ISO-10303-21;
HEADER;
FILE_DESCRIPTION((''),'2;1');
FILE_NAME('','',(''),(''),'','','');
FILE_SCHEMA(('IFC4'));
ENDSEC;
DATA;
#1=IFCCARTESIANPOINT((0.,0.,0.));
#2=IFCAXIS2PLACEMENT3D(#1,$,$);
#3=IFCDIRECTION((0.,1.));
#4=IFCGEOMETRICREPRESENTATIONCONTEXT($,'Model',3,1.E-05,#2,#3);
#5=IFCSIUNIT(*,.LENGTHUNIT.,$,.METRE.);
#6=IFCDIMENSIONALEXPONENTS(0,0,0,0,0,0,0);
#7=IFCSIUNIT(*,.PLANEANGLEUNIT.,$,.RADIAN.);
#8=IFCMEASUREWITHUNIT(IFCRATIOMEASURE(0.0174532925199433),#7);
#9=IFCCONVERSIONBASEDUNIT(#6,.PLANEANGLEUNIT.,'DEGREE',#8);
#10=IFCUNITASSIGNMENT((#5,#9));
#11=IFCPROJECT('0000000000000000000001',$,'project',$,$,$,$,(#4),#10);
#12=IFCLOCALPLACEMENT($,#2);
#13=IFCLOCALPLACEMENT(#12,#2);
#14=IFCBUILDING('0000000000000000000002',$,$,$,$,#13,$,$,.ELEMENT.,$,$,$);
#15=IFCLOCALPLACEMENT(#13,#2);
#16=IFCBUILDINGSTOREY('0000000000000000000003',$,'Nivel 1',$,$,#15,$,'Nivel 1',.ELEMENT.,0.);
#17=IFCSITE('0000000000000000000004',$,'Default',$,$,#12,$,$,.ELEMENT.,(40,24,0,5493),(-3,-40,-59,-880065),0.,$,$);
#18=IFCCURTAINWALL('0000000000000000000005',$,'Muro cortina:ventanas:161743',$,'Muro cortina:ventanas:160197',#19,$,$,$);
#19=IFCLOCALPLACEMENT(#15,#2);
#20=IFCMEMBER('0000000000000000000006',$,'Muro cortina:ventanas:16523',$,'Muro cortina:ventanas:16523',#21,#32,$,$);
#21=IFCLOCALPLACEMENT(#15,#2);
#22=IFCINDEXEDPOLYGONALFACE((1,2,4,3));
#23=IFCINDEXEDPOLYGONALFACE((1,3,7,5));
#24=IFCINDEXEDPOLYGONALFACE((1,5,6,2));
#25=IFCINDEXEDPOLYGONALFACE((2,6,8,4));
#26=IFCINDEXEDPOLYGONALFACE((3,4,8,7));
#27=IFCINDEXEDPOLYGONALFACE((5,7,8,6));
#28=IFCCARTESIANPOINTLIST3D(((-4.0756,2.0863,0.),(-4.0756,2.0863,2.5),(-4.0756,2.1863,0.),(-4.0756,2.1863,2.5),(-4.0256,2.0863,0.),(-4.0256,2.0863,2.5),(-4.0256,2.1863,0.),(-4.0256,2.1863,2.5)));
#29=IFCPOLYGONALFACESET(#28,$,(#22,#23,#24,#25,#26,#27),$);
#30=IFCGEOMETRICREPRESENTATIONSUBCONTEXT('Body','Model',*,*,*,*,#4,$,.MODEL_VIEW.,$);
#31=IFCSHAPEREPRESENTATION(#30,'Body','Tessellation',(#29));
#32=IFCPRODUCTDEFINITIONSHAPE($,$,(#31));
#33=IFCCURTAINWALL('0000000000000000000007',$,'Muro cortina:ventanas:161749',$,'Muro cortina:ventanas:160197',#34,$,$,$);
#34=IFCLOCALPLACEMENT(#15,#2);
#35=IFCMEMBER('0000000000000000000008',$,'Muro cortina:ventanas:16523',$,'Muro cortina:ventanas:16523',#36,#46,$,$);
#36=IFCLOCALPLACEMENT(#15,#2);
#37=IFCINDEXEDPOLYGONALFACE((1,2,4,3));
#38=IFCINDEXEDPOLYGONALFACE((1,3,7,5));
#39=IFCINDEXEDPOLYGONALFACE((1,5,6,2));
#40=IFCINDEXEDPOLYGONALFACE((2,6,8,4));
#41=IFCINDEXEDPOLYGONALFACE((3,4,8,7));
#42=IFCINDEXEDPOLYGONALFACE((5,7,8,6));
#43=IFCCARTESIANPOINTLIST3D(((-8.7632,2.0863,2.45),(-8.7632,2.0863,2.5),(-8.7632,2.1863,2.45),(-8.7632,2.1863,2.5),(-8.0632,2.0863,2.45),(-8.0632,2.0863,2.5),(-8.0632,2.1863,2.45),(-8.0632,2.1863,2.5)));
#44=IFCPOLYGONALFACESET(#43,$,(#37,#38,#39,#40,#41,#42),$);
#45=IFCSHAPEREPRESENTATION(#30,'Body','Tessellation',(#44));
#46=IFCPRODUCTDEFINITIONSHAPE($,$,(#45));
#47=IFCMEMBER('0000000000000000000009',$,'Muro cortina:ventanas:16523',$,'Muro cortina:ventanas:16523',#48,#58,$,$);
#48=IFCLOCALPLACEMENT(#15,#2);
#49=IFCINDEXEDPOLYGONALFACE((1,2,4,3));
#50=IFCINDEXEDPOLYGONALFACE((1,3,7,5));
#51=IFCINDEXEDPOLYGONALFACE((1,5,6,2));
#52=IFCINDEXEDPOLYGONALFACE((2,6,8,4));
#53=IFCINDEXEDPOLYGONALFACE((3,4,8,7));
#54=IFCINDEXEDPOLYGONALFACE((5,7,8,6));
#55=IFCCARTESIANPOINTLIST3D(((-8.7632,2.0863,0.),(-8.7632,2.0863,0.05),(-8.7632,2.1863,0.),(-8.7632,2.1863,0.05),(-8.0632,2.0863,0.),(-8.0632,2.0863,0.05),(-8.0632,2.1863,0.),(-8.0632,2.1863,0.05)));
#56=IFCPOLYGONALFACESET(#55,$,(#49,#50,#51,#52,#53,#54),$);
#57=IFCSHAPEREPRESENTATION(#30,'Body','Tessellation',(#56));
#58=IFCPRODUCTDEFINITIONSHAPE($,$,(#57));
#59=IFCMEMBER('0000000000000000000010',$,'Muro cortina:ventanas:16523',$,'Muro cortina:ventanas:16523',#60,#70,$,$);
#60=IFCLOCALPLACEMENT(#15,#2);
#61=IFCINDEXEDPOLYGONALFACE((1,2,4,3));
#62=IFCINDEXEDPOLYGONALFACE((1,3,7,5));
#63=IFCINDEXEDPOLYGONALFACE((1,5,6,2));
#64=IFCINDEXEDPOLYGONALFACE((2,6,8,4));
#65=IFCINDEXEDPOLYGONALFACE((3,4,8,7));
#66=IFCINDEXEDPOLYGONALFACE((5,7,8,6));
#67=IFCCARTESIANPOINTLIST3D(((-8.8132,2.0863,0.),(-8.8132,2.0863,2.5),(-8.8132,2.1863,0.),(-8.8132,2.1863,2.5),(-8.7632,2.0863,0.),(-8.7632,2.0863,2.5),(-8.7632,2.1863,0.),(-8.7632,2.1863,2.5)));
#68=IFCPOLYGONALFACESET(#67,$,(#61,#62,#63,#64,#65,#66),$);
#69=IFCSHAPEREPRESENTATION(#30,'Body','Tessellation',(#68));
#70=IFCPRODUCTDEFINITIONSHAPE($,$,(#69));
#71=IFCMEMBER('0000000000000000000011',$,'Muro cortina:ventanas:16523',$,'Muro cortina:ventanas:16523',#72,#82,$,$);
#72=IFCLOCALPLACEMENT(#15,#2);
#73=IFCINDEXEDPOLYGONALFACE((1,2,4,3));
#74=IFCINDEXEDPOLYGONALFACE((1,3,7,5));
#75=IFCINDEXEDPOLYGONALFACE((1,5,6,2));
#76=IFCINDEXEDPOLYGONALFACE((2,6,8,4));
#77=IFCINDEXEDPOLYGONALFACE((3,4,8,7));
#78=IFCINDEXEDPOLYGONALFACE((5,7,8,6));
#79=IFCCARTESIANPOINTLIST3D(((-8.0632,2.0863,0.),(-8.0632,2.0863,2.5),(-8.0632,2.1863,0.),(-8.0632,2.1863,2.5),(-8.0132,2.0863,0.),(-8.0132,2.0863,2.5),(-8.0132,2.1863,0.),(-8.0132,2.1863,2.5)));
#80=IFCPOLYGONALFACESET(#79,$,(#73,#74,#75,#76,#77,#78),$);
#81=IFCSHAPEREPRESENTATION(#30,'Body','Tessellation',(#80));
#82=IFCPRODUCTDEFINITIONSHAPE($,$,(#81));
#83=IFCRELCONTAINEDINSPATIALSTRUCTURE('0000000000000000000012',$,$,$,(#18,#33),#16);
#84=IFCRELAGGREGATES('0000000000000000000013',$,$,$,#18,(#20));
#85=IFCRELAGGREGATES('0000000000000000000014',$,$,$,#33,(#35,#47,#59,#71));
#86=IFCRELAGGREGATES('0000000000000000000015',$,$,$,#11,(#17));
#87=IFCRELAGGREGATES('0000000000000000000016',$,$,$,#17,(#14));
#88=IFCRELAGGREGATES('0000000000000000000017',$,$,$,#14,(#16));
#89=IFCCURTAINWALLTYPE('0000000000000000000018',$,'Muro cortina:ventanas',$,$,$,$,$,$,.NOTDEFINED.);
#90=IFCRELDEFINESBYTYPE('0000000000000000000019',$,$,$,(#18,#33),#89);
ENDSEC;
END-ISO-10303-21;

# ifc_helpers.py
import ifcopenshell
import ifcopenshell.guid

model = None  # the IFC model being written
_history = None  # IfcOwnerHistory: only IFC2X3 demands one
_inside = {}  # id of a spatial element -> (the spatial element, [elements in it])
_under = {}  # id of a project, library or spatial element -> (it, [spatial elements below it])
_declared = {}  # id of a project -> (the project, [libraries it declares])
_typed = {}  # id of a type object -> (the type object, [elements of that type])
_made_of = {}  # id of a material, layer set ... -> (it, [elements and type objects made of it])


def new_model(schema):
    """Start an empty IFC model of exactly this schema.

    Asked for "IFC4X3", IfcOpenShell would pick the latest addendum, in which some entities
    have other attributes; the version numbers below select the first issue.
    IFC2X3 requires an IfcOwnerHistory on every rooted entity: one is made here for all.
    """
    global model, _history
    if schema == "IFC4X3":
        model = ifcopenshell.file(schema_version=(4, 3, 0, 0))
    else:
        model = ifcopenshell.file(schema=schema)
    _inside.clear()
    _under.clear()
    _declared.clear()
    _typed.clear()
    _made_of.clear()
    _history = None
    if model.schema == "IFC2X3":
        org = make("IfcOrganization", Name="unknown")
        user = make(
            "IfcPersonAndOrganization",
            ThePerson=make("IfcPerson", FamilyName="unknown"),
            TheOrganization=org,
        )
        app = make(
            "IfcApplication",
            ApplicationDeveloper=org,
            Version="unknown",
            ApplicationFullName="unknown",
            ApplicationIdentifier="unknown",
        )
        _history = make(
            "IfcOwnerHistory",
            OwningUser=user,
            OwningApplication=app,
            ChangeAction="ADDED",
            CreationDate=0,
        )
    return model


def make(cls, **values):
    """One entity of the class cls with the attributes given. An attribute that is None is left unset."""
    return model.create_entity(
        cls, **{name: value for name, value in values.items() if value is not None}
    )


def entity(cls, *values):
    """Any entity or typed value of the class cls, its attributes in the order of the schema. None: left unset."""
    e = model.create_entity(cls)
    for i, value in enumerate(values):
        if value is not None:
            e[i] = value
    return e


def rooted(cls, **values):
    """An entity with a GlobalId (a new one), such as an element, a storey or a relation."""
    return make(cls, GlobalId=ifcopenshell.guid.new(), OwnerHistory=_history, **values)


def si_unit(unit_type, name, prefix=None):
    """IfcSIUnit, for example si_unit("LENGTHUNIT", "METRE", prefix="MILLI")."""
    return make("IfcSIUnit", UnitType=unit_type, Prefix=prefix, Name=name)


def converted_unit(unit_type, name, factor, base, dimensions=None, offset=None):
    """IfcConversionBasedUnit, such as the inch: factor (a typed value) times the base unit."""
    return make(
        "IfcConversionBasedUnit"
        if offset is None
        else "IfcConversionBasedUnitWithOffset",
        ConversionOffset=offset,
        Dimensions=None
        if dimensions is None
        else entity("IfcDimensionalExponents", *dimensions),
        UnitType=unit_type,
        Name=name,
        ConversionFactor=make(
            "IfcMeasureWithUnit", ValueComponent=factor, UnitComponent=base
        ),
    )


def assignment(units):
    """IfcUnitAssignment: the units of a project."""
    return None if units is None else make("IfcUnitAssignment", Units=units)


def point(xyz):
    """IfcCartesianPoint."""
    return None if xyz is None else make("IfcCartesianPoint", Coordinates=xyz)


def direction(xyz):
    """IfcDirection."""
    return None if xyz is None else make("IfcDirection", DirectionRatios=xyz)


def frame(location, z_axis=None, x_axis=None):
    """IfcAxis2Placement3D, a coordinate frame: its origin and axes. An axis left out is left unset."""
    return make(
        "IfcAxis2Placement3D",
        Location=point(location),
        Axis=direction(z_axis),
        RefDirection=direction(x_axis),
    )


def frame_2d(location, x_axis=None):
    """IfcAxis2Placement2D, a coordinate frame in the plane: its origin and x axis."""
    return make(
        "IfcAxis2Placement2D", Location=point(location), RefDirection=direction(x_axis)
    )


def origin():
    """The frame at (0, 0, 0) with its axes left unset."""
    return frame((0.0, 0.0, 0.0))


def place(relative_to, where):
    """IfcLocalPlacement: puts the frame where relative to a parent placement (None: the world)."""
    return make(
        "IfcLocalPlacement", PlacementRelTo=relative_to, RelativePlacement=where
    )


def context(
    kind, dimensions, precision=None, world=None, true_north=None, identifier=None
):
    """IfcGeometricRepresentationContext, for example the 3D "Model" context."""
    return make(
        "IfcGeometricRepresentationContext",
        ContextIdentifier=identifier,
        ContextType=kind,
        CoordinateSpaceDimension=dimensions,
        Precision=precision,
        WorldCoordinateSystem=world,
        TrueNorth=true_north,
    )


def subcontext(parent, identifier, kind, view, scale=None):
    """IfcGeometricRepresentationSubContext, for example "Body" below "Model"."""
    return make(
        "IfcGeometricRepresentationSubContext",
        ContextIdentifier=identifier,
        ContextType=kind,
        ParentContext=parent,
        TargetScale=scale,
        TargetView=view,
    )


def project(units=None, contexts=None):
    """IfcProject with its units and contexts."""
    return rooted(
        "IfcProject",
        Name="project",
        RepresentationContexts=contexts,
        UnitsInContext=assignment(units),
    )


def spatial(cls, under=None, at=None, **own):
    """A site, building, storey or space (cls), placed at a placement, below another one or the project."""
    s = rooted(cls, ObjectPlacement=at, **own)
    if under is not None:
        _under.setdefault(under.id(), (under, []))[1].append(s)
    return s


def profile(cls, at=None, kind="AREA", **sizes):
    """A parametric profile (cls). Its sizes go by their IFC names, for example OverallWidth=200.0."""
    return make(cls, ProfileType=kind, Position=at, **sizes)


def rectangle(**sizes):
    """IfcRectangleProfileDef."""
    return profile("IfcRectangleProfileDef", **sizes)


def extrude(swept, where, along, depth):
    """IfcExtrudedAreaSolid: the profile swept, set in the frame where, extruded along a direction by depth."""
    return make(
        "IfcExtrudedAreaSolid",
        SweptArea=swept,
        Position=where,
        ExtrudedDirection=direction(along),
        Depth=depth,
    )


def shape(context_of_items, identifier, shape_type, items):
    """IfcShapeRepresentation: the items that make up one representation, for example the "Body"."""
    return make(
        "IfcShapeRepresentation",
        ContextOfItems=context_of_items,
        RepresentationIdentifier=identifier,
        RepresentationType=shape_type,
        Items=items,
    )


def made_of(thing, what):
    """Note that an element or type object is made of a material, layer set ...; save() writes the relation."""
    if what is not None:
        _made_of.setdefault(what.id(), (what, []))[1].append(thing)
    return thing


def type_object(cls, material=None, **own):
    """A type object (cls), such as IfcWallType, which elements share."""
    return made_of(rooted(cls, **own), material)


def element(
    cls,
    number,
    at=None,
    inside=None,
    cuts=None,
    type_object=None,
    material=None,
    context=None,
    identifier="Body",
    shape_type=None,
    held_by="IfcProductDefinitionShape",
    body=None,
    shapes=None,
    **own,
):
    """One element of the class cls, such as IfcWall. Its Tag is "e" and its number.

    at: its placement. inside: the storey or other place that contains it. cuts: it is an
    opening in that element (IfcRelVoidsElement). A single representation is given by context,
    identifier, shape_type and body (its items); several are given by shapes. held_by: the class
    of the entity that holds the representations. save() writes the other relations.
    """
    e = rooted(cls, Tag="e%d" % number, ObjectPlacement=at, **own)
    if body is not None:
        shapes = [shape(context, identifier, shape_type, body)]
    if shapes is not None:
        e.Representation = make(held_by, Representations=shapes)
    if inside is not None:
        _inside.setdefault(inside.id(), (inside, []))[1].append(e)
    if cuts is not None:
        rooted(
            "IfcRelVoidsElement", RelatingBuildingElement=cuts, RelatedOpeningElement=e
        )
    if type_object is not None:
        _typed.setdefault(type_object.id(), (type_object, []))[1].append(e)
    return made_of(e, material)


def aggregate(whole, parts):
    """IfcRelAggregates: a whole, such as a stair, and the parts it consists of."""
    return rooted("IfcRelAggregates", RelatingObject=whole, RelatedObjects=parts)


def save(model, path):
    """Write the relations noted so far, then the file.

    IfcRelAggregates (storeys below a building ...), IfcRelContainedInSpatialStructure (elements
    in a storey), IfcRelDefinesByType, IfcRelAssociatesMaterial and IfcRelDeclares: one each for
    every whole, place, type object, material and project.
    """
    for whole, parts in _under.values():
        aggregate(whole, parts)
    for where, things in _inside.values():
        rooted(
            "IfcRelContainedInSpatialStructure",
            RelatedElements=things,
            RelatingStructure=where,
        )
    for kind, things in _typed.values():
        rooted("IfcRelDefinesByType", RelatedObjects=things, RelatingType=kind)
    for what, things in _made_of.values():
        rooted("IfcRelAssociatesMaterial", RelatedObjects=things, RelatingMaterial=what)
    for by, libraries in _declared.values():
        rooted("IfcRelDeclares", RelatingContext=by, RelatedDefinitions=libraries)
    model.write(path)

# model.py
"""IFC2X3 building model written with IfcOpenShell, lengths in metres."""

from ifc_helpers import new_model, entity, si_unit, converted_unit, direction, frame, frame_2d, origin, place, context, subcontext, project, spatial, rectangle, extrude, type_object, element, aggregate, save


model = new_model("IFC2X3")

# Units and contexts
model_context = context("Model", 3, precision=1e-05, world=origin(), true_north=direction((0.0, 1.0)))
body_context = subcontext(model_context, "Body", "Model", "MODEL_VIEW")
ifc_project = project(units=[si_unit("LENGTHUNIT", "METRE"), converted_unit("PLANEANGLEUNIT", "DEGREE", entity("IfcRatioMeasure", 0.0174532925199433), si_unit("PLANEANGLEUNIT", "RADIAN"), dimensions=[0, 0, 0, 0, 0, 0, 0])], contexts=[model_context])

# Site, building, storey
site_placement = place(None, origin())
site = spatial("IfcSite", under=ifc_project, at=site_placement, Name="Default", CompositionType="ELEMENT", RefLatitude=(40, 24, 0, 5493), RefLongitude=(-3, -40, -59, -880065), RefElevation=0.0)
building_placement = place(site_placement, origin())
building = spatial("IfcBuilding", under=site, at=building_placement, CompositionType="ELEMENT")
storey_placement = place(building_placement, origin())
storey = spatial("IfcBuildingStorey", under=building, at=storey_placement, Name="Nivel 1", LongName="Nivel 1", CompositionType="ELEMENT", Elevation=0.0)

# Curtain walls, members
curtain_wall_type = type_object("IfcCurtainWallType", Name="Muro cortina:ventanas", PredefinedType="NOTDEFINED")
curtain_wall_1_placement = place(storey_placement, origin())
curtain_wall_1 = element("IfcCurtainWall", 1, at=curtain_wall_1_placement, inside=storey, type_object=curtain_wall_type, Name="Muro cortina:ventanas:161743", ObjectType="Muro cortina:ventanas:160197")
member_1_placement = place(curtain_wall_1_placement, origin())
member_1 = element("IfcMember", 2, at=member_1_placement, Name="Muro cortina:ventanas:16523", ObjectType="Muro cortina:ventanas:16523", context=body_context, shape_type="SweptSolid", body=[
    extrude(rectangle(XDim=0.05, YDim=0.1, at=frame_2d((0.0, 0.0), x_axis=(1.0, 0.0))), frame((-4.0506, 2.1363, 2.5), z_axis=(0.0, 0.0, -1.0), x_axis=(-1.0, 0.0, 0.0)), (0.0, 0.0, 1.0), 2.5),
])
aggregate(curtain_wall_1, [member_1])
curtain_wall_2_placement = place(storey_placement, origin())
curtain_wall_2 = element("IfcCurtainWall", 3, at=curtain_wall_2_placement, inside=storey, type_object=curtain_wall_type, Name="Muro cortina:ventanas:161749", ObjectType="Muro cortina:ventanas:160197")
member_2_placement = place(curtain_wall_2_placement, origin())
member_2 = element("IfcMember", 4, at=member_2_placement, Name="Muro cortina:ventanas:16523", ObjectType="Muro cortina:ventanas:16523", context=body_context, shape_type="SweptSolid", body=[
    extrude(rectangle(XDim=0.05, YDim=0.1, at=frame_2d((0.0, 0.0), x_axis=(1.0, 0.0))), frame((-8.7632, 2.1363, 2.475), z_axis=(1.0, 0.0, 0.0), x_axis=(0.0, 0.0, -1.0)), (0.0, 0.0, 1.0), 0.7),
])
member_3_placement = place(curtain_wall_2_placement, origin())
member_3 = element("IfcMember", 5, at=member_3_placement, Name="Muro cortina:ventanas:16523", ObjectType="Muro cortina:ventanas:16523", context=body_context, shape_type="SweptSolid", body=[
    extrude(rectangle(XDim=0.05, YDim=0.1, at=frame_2d((0.0, 0.0), x_axis=(1.0, 0.0))), frame((-8.0632, 2.1363, 0.025), z_axis=(-1.0, 0.0, 0.0), x_axis=(0.0, 0.0, -1.0)), (0.0, 0.0, 1.0), 0.7),
])
member_4_placement = place(curtain_wall_2_placement, origin())
member_4 = element("IfcMember", 6, at=member_4_placement, Name="Muro cortina:ventanas:16523", ObjectType="Muro cortina:ventanas:16523", context=body_context, shape_type="SweptSolid", body=[
    extrude(rectangle(XDim=0.05, YDim=0.1, at=frame_2d((0.0, 0.0), x_axis=(1.0, 0.0))), frame((-8.7882, 2.1363, 0.0), z_axis=(0.0, 0.0, 1.0), x_axis=(-1.0, 0.0, 0.0)), (0.0, 0.0, 1.0), 2.5),
])
member_5_placement = place(curtain_wall_2_placement, origin())
member_5 = element("IfcMember", 7, at=member_5_placement, Name="Muro cortina:ventanas:16523", ObjectType="Muro cortina:ventanas:16523", context=body_context, shape_type="SweptSolid", body=[
    extrude(rectangle(XDim=0.05, YDim=0.1, at=frame_2d((0.0, 0.0), x_axis=(1.0, 0.0))), frame((-8.0382, 2.1363, 2.5), z_axis=(0.0, 0.0, -1.0), x_axis=(-1.0, 0.0, 0.0)), (0.0, 0.0, 1.0), 2.5),
])
aggregate(curtain_wall_2, [member_2, member_3, member_4, member_5])

save(model, "model.ifc")
